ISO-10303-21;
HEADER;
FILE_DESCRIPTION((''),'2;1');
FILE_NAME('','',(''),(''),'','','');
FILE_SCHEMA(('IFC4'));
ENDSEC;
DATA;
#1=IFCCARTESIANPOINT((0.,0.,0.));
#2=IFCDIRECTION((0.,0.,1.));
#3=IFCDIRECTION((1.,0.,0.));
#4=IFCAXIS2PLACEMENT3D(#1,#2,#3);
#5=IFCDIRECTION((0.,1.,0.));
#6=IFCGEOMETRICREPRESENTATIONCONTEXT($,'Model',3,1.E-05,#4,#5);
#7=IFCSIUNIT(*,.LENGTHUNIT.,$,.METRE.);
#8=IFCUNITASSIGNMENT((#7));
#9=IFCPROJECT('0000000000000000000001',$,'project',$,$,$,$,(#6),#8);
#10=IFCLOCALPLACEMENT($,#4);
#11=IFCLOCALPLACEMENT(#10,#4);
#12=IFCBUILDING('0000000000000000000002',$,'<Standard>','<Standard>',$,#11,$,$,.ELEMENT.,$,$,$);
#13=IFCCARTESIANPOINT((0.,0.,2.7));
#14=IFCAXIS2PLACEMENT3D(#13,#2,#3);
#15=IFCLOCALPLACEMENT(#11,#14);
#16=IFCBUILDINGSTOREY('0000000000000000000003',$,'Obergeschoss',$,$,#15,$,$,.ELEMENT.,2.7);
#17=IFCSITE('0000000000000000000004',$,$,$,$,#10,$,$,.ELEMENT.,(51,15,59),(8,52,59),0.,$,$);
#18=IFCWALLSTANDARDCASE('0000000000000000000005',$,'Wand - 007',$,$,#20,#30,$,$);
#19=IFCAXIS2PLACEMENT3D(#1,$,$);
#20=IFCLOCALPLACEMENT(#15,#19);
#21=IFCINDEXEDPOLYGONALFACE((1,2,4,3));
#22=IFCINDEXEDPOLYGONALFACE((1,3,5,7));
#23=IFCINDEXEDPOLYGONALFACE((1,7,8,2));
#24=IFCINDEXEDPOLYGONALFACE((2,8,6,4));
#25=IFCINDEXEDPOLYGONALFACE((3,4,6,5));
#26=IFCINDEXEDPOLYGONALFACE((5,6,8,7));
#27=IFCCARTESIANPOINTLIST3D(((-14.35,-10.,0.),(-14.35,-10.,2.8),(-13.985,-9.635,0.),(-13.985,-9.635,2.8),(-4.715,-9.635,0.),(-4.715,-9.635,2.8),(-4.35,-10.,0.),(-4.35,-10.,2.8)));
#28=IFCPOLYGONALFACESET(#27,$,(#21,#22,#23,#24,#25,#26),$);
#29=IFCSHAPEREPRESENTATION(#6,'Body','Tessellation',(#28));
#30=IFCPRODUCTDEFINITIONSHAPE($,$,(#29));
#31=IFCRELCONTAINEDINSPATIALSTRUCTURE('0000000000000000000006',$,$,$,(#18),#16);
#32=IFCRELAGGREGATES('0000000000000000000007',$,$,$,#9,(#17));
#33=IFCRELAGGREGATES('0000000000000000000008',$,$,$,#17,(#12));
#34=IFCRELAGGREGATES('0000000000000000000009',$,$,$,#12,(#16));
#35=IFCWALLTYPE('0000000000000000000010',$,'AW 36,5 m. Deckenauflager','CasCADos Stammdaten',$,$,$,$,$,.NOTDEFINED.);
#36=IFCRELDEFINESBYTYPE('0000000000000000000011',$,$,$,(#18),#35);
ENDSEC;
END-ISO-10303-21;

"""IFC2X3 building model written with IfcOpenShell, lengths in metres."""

from ifc_helpers import new_model, si_unit, direction, frame, origin_with_axes, place, context, project, spatial, polyline, outline, extrude, type_object, element, save


model = new_model("IFC2X3")

# Units and contexts
model_context = context("Model", 3, precision=1e-05, world=origin_with_axes(), true_north=direction((0.0, 1.0, 0.0)))
ifc_project = project(units=[si_unit("LENGTHUNIT", "METRE")], contexts=[model_context])

# Site, building, storey
site_placement = place(None, origin_with_axes())
site = spatial("IfcSite", under=ifc_project, at=site_placement, CompositionType="ELEMENT", RefLatitude=(51, 15, 59), RefLongitude=(8, 52, 59), RefElevation=0.0)
building_placement = place(site_placement, origin_with_axes())
building = spatial("IfcBuilding", under=site, at=building_placement, Name="<Standard>", Description="<Standard>", CompositionType="ELEMENT")
storey_placement = place(building_placement, frame((0.0, 0.0, 2.7), z_axis=(0.0, 0.0, 1.0), x_axis=(1.0, 0.0, 0.0)))
storey = spatial("IfcBuildingStorey", under=building, at=storey_placement, Name="Obergeschoss", CompositionType="ELEMENT", Elevation=2.7)

# Wall
wall_type_1 = type_object("IfcWallType", Name="AW 36,5 m. Deckenauflager", Description="CasCADos Stammdaten", PredefinedType="NOTDEFINED")
wall_1_placement = place(storey_placement, frame((-14.35, -10.0, 0.0), z_axis=(0.0, 0.0, 1.0), x_axis=(1.0, 0.0, 0.0)))
element("IfcWallStandardCase", 1, at=wall_1_placement, inside=storey, type_object=wall_type_1, Name="Wand - 007", context=model_context, shape_type="SweptSolid", body=[
    extrude(outline(polyline([(0.365, 0.365), (0.0, 0.0), (10.0, 0.0), (9.635, 0.365), (0.365, 0.365)])), origin_with_axes(), (0.0, 0.0, 1.0), 2.8),
])

save(model, "model.ifc")
